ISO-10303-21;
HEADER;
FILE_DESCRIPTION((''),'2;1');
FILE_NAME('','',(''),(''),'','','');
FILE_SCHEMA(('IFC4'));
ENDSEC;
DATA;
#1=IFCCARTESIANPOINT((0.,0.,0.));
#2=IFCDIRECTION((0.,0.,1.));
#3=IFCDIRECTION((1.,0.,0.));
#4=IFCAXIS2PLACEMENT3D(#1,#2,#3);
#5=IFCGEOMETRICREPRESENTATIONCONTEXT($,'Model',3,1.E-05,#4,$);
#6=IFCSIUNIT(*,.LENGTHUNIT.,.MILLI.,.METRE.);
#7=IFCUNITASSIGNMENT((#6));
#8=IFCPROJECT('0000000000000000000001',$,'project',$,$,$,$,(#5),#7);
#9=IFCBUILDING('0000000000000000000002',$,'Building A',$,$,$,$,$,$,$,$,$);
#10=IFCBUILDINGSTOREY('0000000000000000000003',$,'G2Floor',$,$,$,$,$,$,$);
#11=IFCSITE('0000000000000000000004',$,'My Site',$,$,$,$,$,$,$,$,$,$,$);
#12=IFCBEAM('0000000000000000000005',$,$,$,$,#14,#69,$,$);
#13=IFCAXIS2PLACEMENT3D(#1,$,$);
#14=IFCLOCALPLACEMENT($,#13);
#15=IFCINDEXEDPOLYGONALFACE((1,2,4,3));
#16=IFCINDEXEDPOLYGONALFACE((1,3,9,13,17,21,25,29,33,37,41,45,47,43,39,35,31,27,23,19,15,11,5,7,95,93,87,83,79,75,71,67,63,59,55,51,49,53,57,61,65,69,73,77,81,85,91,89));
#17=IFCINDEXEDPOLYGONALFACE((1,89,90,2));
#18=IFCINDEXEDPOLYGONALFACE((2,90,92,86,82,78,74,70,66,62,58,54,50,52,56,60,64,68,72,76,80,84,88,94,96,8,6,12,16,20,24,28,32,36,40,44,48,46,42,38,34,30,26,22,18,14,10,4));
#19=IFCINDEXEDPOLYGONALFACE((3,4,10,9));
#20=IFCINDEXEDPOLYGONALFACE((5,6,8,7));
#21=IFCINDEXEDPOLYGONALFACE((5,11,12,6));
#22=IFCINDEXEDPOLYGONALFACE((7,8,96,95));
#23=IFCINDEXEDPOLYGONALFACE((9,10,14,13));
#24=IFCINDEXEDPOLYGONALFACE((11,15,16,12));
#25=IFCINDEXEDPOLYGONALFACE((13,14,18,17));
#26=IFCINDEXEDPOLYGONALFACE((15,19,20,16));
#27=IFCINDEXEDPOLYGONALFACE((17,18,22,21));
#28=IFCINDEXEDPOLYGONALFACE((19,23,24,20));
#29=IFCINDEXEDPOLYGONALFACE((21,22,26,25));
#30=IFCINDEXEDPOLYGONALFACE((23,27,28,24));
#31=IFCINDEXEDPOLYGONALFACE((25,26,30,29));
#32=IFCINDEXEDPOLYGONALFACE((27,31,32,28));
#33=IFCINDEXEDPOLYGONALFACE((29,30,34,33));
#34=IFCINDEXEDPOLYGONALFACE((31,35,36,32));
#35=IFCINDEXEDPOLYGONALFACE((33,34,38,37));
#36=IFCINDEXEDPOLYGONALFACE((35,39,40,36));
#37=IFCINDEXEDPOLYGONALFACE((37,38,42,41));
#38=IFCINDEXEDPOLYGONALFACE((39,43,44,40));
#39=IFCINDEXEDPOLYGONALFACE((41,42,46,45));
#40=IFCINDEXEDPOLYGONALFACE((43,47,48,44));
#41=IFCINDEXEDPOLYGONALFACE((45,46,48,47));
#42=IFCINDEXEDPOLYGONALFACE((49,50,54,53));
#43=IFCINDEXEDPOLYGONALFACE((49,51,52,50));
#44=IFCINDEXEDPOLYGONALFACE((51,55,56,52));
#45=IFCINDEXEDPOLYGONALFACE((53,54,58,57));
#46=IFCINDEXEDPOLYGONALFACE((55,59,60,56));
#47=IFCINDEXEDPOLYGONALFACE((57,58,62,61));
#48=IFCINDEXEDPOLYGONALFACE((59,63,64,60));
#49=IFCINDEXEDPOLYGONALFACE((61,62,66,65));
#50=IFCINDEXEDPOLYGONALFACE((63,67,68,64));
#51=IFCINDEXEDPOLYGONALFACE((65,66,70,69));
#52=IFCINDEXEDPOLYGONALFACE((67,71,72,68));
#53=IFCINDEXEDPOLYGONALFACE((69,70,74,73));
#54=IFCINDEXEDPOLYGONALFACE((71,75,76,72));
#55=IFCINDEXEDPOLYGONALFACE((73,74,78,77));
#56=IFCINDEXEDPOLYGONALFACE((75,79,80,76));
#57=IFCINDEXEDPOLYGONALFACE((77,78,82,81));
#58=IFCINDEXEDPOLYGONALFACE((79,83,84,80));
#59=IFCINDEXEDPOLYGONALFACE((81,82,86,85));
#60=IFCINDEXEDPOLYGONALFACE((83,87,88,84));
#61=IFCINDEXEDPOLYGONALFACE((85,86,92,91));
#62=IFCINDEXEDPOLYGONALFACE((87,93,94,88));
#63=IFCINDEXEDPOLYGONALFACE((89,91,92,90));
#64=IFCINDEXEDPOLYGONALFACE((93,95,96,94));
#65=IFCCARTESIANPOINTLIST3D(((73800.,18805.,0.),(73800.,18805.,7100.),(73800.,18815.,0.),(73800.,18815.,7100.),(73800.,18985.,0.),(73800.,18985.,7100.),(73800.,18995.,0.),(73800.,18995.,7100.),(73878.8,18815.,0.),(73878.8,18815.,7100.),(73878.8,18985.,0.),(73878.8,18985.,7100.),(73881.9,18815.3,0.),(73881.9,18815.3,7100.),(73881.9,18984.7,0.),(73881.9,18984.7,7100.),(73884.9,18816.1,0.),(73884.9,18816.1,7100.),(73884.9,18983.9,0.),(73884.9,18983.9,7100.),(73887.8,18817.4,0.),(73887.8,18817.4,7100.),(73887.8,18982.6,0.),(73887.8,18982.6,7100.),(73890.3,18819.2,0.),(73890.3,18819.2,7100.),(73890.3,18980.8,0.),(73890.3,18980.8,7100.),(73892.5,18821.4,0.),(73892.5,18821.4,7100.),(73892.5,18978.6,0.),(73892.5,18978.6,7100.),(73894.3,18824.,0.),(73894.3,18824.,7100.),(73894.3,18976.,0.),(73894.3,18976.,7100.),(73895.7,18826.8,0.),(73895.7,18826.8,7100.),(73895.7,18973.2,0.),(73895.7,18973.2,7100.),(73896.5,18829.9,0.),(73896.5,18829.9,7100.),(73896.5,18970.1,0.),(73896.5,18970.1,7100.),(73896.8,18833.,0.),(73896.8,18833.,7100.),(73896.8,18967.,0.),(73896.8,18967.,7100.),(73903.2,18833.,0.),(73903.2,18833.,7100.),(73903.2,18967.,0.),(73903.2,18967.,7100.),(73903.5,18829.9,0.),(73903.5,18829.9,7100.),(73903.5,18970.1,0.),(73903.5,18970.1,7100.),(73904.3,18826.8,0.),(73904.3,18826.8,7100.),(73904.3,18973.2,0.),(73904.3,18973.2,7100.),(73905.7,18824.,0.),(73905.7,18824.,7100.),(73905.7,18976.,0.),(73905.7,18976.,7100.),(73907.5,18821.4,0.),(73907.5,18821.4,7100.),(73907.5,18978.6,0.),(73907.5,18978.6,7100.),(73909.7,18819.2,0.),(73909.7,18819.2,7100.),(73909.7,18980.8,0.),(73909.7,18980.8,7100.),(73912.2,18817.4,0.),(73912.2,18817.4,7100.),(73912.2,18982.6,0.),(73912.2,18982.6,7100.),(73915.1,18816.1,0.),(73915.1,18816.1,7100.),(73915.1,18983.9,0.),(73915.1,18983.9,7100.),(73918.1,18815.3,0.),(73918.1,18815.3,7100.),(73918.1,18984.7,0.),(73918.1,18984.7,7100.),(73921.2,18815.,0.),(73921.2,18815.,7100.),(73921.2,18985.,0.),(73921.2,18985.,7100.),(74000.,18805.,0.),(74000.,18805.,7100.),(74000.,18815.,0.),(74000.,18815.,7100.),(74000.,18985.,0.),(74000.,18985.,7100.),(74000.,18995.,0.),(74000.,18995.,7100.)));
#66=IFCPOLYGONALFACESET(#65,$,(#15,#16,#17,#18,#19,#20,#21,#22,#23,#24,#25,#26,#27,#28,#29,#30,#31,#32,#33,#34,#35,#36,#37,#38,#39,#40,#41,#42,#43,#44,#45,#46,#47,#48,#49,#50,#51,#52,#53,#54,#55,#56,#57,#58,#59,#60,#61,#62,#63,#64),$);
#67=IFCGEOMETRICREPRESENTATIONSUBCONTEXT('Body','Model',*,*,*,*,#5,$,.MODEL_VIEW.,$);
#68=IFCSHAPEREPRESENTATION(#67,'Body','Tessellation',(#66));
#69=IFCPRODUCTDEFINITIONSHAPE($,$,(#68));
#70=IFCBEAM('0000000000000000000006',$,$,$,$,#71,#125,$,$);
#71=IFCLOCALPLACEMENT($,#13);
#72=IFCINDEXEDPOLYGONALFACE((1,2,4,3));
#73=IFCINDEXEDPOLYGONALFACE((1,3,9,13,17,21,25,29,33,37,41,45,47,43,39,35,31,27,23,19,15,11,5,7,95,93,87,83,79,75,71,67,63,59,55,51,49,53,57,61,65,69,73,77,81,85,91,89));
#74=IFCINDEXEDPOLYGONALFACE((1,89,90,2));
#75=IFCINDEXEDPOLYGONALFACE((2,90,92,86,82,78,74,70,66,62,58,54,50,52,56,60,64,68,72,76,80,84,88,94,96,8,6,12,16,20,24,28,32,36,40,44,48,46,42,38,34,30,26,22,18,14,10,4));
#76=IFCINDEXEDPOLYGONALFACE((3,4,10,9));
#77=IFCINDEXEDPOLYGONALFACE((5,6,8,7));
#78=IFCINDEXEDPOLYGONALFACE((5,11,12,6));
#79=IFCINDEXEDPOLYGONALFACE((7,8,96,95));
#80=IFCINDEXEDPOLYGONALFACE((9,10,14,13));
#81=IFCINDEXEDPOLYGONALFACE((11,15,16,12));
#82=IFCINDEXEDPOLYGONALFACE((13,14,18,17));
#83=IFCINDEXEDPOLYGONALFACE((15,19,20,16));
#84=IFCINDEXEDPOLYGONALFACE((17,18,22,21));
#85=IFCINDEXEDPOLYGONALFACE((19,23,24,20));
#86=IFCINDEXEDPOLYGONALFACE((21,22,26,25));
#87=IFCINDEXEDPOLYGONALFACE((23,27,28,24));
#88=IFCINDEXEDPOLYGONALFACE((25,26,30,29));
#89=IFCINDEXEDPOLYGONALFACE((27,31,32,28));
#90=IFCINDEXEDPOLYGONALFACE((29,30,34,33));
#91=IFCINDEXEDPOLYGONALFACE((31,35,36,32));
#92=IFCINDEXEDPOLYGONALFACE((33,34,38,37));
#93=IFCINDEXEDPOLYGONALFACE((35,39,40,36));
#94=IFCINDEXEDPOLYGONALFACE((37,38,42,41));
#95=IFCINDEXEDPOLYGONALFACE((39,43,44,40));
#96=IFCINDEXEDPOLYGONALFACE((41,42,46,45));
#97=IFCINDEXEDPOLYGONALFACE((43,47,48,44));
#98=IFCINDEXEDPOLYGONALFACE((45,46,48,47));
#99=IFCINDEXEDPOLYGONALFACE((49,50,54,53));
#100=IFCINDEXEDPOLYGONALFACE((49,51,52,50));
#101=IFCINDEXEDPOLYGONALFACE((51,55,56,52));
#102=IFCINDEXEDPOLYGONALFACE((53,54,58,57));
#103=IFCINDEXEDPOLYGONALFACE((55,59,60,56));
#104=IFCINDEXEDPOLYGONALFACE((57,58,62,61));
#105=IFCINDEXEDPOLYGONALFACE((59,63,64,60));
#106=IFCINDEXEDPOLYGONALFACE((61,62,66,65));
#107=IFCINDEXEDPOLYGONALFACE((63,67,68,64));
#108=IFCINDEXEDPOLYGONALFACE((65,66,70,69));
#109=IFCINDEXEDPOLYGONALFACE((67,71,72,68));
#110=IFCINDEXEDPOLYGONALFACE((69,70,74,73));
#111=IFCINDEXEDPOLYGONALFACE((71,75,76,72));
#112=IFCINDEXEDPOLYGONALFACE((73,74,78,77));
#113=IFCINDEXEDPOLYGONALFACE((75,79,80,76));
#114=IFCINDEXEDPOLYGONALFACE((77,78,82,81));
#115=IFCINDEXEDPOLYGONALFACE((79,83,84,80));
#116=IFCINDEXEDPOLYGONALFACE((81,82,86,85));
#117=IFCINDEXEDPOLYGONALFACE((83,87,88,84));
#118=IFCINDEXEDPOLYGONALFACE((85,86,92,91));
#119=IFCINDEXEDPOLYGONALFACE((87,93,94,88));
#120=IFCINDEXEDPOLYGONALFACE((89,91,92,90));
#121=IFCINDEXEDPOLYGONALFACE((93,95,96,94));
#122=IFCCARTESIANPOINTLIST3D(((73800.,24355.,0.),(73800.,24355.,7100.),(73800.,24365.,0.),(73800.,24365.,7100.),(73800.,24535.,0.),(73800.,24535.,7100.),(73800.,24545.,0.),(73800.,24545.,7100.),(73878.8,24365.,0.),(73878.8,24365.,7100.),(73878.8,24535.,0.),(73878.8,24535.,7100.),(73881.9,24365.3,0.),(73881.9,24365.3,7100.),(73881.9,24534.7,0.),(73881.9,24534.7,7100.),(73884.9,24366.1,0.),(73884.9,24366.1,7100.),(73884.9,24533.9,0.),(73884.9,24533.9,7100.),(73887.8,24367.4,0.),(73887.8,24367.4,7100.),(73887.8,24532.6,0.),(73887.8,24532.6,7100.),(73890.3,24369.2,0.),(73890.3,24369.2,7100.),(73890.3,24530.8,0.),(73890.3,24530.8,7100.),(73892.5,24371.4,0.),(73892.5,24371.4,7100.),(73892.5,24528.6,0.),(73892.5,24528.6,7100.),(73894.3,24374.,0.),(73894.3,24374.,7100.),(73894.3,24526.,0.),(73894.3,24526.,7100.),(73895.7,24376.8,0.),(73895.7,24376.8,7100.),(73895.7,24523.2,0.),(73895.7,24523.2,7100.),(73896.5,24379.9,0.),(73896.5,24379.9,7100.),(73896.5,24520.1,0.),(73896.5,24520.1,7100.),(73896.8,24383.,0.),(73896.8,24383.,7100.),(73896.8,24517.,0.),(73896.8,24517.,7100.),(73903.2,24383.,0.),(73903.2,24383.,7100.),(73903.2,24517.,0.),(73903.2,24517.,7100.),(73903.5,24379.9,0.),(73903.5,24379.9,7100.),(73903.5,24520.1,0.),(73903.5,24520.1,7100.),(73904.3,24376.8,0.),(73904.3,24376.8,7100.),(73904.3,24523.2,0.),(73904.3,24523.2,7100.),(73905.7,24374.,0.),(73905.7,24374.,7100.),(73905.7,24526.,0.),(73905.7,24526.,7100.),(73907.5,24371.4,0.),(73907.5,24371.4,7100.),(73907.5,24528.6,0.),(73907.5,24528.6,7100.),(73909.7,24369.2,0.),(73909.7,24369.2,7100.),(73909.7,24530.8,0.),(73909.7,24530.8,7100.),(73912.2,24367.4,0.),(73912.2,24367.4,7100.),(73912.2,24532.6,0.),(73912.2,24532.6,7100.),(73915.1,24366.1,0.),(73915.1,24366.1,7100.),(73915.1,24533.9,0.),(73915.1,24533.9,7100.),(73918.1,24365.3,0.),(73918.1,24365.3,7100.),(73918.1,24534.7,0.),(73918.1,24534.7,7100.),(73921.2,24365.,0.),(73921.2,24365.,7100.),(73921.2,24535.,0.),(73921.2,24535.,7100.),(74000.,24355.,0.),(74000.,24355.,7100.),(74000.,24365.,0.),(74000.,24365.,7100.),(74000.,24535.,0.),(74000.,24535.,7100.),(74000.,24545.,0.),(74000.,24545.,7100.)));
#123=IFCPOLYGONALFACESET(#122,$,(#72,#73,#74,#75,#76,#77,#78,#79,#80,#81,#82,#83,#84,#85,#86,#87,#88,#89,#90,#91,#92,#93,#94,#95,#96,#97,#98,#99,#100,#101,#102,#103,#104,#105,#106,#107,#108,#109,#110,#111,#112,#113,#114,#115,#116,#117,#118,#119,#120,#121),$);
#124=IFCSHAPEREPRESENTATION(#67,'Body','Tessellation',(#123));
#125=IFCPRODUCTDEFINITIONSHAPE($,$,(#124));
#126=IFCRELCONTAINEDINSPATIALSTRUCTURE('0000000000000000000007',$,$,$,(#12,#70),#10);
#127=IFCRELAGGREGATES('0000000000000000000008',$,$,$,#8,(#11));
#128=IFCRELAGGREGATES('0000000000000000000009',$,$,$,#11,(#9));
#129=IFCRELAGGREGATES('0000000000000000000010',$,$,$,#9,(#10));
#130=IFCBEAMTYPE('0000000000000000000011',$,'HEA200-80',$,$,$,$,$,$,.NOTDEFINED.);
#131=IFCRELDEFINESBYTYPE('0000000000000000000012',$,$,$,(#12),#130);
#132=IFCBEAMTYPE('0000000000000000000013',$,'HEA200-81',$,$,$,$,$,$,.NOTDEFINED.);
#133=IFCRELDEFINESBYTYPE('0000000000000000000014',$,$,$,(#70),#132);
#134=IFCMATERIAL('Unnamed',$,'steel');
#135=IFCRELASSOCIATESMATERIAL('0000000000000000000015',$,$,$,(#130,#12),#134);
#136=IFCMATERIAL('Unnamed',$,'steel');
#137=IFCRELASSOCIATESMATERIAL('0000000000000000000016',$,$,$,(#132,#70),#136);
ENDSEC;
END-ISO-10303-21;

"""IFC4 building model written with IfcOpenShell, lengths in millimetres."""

from ifc_helpers import new_model, si_unit, frame, origin_with_axes, place, context, subcontext, project, spatial, polyline, outline, extrude, material, material_profile, profile_set, profile_usage, type_object, element, save


model = new_model("IFC4")

# Units and contexts
model_context = context("Model", 3, precision=1e-05, world=origin_with_axes())
body_context = subcontext(model_context, "Body", "Model", "MODEL_VIEW")
ifc_project = project(units=[si_unit("LENGTHUNIT", "METRE", prefix="MILLI")], contexts=[model_context])

# Site, building, storey
site = spatial("IfcSite", under=ifc_project, Name="My Site")
building = spatial("IfcBuilding", under=site, Name="Building A")
storey = spatial("IfcBuildingStorey", under=building, Name="G2Floor")

# Beams
ifc_material_1 = material(Name="Unnamed", Category="steel")
ifc_material_profile_1 = material_profile(ifc_material_1, outline(polyline([(100.0, -95.0), (100.0, -85.0), (100.0, -85.0), (21.2, -85.0), (21.2, -85.0), (18.1, -84.7), (18.1, -84.7), (15.1, -83.9), (15.1, -83.9), (12.2, -82.6), (12.2, -82.6), (9.7, -80.8), (9.7, -80.8), (7.5, -78.6), (7.5, -78.6), (5.7, -76.0), (5.7, -76.0), (4.3, -73.2), (4.3, -73.2), (3.5, -70.1), (3.5, -70.1), (3.2, -67.0), (3.2, -67.0), (3.2, 67.0), (3.2, 67.0), (3.5, 70.1), (3.5, 70.1), (4.3, 73.2), (4.3, 73.2), (5.7, 76.0), (5.7, 76.0), (7.5, 78.6), (7.5, 78.6), (9.7, 80.8), (9.7, 80.8), (12.2, 82.6), (12.2, 82.6), (15.1, 83.9), (15.1, 83.9), (18.1, 84.7), (18.1, 84.7), (21.2, 85.0), (21.2, 85.0), (100.0, 85.0), (100.0, 85.0), (100.0, 95.0), (100.0, 95.0), (-100.0, 95.0), (-100.0, 95.0), (-100.0, 85.0), (-100.0, 85.0), (-21.2, 85.0), (-21.2, 85.0), (-18.1, 84.7), (-18.1, 84.7), (-15.1, 83.9), (-15.1, 83.9), (-12.2, 82.6), (-12.2, 82.6), (-9.7, 80.8), (-9.7, 80.8), (-7.5, 78.6), (-7.5, 78.6), (-5.7, 76.0), (-5.7, 76.0), (-4.3, 73.2), (-4.3, 73.2), (-3.5, 70.1), (-3.5, 70.1), (-3.2, 67.0), (-3.2, 67.0), (-3.2, -67.0), (-3.2, -67.0), (-3.5, -70.1), (-3.5, -70.1), (-4.3, -73.2), (-4.3, -73.2), (-5.7, -76.0), (-5.7, -76.0), (-7.5, -78.6), (-7.5, -78.6), (-9.7, -80.8), (-9.7, -80.8), (-12.2, -82.6), (-12.2, -82.6), (-15.1, -83.9), (-15.1, -83.9), (-18.1, -84.7), (-18.1, -84.7), (-21.2, -85.0), (-21.2, -85.0), (-100.0, -85.0), (-100.0, -85.0), (-100.0, -95.0), (-100.0, -95.0), (100.0, -95.0)])))
ifc_profile_set_1 = profile_set([ifc_material_profile_1], Name="HEA200-80")
ifc_profile_usage_1 = profile_usage(ifc_profile_set_1)
beam_type_1 = type_object("IfcBeamType", Name="HEA200-80", PredefinedType="NOTDEFINED", material=ifc_profile_set_1)
beam_1_placement = place(None, frame((73900.0, 18900.0, 0.0), z_axis=(0.0, 0.0, 1.0), x_axis=(1.0, 0.0, 0.0)))
element("IfcBeam", 1, at=beam_1_placement, inside=storey, type_object=beam_type_1, material=ifc_profile_usage_1, context=body_context, shape_type="SweptSolid", body=[
    extrude(outline(polyline([(100.0, -95.0), (100.0, -85.0), (100.0, -85.0), (21.2, -85.0), (21.2, -85.0), (18.1, -84.7), (18.1, -84.7), (15.1, -83.9), (15.1, -83.9), (12.2, -82.6), (12.2, -82.6), (9.7, -80.8), (9.7, -80.8), (7.5, -78.6), (7.5, -78.6), (5.7, -76.0), (5.7, -76.0), (4.3, -73.2), (4.3, -73.2), (3.5, -70.1), (3.5, -70.1), (3.2, -67.0), (3.2, -67.0), (3.2, 67.0), (3.2, 67.0), (3.5, 70.1), (3.5, 70.1), (4.3, 73.2), (4.3, 73.2), (5.7, 76.0), (5.7, 76.0), (7.5, 78.6), (7.5, 78.6), (9.7, 80.8), (9.7, 80.8), (12.2, 82.6), (12.2, 82.6), (15.1, 83.9), (15.1, 83.9), (18.1, 84.7), (18.1, 84.7), (21.2, 85.0), (21.2, 85.0), (100.0, 85.0), (100.0, 85.0), (100.0, 95.0), (100.0, 95.0), (-100.0, 95.0), (-100.0, 95.0), (-100.0, 85.0), (-100.0, 85.0), (-21.2, 85.0), (-21.2, 85.0), (-18.1, 84.7), (-18.1, 84.7), (-15.1, 83.9), (-15.1, 83.9), (-12.2, 82.6), (-12.2, 82.6), (-9.7, 80.8), (-9.7, 80.8), (-7.5, 78.6), (-7.5, 78.6), (-5.7, 76.0), (-5.7, 76.0), (-4.3, 73.2), (-4.3, 73.2), (-3.5, 70.1), (-3.5, 70.1), (-3.2, 67.0), (-3.2, 67.0), (-3.2, -67.0), (-3.2, -67.0), (-3.5, -70.1), (-3.5, -70.1), (-4.3, -73.2), (-4.3, -73.2), (-5.7, -76.0), (-5.7, -76.0), (-7.5, -78.6), (-7.5, -78.6), (-9.7, -80.8), (-9.7, -80.8), (-12.2, -82.6), (-12.2, -82.6), (-15.1, -83.9), (-15.1, -83.9), (-18.1, -84.7), (-18.1, -84.7), (-21.2, -85.0), (-21.2, -85.0), (-100.0, -85.0), (-100.0, -85.0), (-100.0, -95.0), (-100.0, -95.0), (100.0, -95.0)])), origin_with_axes(), (0.0, 0.0, 1.0), 7100.0),
])
ifc_material_2 = material(Name="Unnamed", Category="steel")
ifc_material_profile_2 = material_profile(ifc_material_2, outline(polyline([(100.0, -95.0), (100.0, -85.0), (100.0, -85.0), (21.2, -85.0), (21.2, -85.0), (18.1, -84.7), (18.1, -84.7), (15.1, -83.9), (15.1, -83.9), (12.2, -82.6), (12.2, -82.6), (9.7, -80.8), (9.7, -80.8), (7.5, -78.6), (7.5, -78.6), (5.7, -76.0), (5.7, -76.0), (4.3, -73.2), (4.3, -73.2), (3.5, -70.1), (3.5, -70.1), (3.2, -67.0), (3.2, -67.0), (3.2, 67.0), (3.2, 67.0), (3.5, 70.1), (3.5, 70.1), (4.3, 73.2), (4.3, 73.2), (5.7, 76.0), (5.7, 76.0), (7.5, 78.6), (7.5, 78.6), (9.7, 80.8), (9.7, 80.8), (12.2, 82.6), (12.2, 82.6), (15.1, 83.9), (15.1, 83.9), (18.1, 84.7), (18.1, 84.7), (21.2, 85.0), (21.2, 85.0), (100.0, 85.0), (100.0, 85.0), (100.0, 95.0), (100.0, 95.0), (-100.0, 95.0), (-100.0, 95.0), (-100.0, 85.0), (-100.0, 85.0), (-21.2, 85.0), (-21.2, 85.0), (-18.1, 84.7), (-18.1, 84.7), (-15.1, 83.9), (-15.1, 83.9), (-12.2, 82.6), (-12.2, 82.6), (-9.7, 80.8), (-9.7, 80.8), (-7.5, 78.6), (-7.5, 78.6), (-5.7, 76.0), (-5.7, 76.0), (-4.3, 73.2), (-4.3, 73.2), (-3.5, 70.1), (-3.5, 70.1), (-3.2, 67.0), (-3.2, 67.0), (-3.2, -67.0), (-3.2, -67.0), (-3.5, -70.1), (-3.5, -70.1), (-4.3, -73.2), (-4.3, -73.2), (-5.7, -76.0), (-5.7, -76.0), (-7.5, -78.6), (-7.5, -78.6), (-9.7, -80.8), (-9.7, -80.8), (-12.2, -82.6), (-12.2, -82.6), (-15.1, -83.9), (-15.1, -83.9), (-18.1, -84.7), (-18.1, -84.7), (-21.2, -85.0), (-21.2, -85.0), (-100.0, -85.0), (-100.0, -85.0), (-100.0, -95.0), (-100.0, -95.0), (100.0, -95.0)])))
ifc_profile_set_2 = profile_set([ifc_material_profile_2], Name="HEA200-81")
ifc_profile_usage_2 = profile_usage(ifc_profile_set_2)
beam_type_2 = type_object("IfcBeamType", Name="HEA200-81", PredefinedType="NOTDEFINED", material=ifc_profile_set_2)
beam_2_placement = place(None, frame((73900.0, 24450.0, 0.0), z_axis=(0.0, 0.0, 1.0), x_axis=(1.0, 0.0, 0.0)))
element("IfcBeam", 2, at=beam_2_placement, inside=storey, type_object=beam_type_2, material=ifc_profile_usage_2, context=body_context, shape_type="SweptSolid", body=[
    extrude(outline(polyline([(100.0, -95.0), (100.0, -85.0), (100.0, -85.0), (21.2, -85.0), (21.2, -85.0), (18.1, -84.7), (18.1, -84.7), (15.1, -83.9), (15.1, -83.9), (12.2, -82.6), (12.2, -82.6), (9.7, -80.8), (9.7, -80.8), (7.5, -78.6), (7.5, -78.6), (5.7, -76.0), (5.7, -76.0), (4.3, -73.2), (4.3, -73.2), (3.5, -70.1), (3.5, -70.1), (3.2, -67.0), (3.2, -67.0), (3.2, 67.0), (3.2, 67.0), (3.5, 70.1), (3.5, 70.1), (4.3, 73.2), (4.3, 73.2), (5.7, 76.0), (5.7, 76.0), (7.5, 78.6), (7.5, 78.6), (9.7, 80.8), (9.7, 80.8), (12.2, 82.6), (12.2, 82.6), (15.1, 83.9), (15.1, 83.9), (18.1, 84.7), (18.1, 84.7), (21.2, 85.0), (21.2, 85.0), (100.0, 85.0), (100.0, 85.0), (100.0, 95.0), (100.0, 95.0), (-100.0, 95.0), (-100.0, 95.0), (-100.0, 85.0), (-100.0, 85.0), (-21.2, 85.0), (-21.2, 85.0), (-18.1, 84.7), (-18.1, 84.7), (-15.1, 83.9), (-15.1, 83.9), (-12.2, 82.6), (-12.2, 82.6), (-9.7, 80.8), (-9.7, 80.8), (-7.5, 78.6), (-7.5, 78.6), (-5.7, 76.0), (-5.7, 76.0), (-4.3, 73.2), (-4.3, 73.2), (-3.5, 70.1), (-3.5, 70.1), (-3.2, 67.0), (-3.2, 67.0), (-3.2, -67.0), (-3.2, -67.0), (-3.5, -70.1), (-3.5, -70.1), (-4.3, -73.2), (-4.3, -73.2), (-5.7, -76.0), (-5.7, -76.0), (-7.5, -78.6), (-7.5, -78.6), (-9.7, -80.8), (-9.7, -80.8), (-12.2, -82.6), (-12.2, -82.6), (-15.1, -83.9), (-15.1, -83.9), (-18.1, -84.7), (-18.1, -84.7), (-21.2, -85.0), (-21.2, -85.0), (-100.0, -85.0), (-100.0, -85.0), (-100.0, -95.0), (-100.0, -95.0), (100.0, -95.0)])), origin_with_axes(), (0.0, 0.0, 1.0), 7100.0),
])

save(model, "model.ifc")
